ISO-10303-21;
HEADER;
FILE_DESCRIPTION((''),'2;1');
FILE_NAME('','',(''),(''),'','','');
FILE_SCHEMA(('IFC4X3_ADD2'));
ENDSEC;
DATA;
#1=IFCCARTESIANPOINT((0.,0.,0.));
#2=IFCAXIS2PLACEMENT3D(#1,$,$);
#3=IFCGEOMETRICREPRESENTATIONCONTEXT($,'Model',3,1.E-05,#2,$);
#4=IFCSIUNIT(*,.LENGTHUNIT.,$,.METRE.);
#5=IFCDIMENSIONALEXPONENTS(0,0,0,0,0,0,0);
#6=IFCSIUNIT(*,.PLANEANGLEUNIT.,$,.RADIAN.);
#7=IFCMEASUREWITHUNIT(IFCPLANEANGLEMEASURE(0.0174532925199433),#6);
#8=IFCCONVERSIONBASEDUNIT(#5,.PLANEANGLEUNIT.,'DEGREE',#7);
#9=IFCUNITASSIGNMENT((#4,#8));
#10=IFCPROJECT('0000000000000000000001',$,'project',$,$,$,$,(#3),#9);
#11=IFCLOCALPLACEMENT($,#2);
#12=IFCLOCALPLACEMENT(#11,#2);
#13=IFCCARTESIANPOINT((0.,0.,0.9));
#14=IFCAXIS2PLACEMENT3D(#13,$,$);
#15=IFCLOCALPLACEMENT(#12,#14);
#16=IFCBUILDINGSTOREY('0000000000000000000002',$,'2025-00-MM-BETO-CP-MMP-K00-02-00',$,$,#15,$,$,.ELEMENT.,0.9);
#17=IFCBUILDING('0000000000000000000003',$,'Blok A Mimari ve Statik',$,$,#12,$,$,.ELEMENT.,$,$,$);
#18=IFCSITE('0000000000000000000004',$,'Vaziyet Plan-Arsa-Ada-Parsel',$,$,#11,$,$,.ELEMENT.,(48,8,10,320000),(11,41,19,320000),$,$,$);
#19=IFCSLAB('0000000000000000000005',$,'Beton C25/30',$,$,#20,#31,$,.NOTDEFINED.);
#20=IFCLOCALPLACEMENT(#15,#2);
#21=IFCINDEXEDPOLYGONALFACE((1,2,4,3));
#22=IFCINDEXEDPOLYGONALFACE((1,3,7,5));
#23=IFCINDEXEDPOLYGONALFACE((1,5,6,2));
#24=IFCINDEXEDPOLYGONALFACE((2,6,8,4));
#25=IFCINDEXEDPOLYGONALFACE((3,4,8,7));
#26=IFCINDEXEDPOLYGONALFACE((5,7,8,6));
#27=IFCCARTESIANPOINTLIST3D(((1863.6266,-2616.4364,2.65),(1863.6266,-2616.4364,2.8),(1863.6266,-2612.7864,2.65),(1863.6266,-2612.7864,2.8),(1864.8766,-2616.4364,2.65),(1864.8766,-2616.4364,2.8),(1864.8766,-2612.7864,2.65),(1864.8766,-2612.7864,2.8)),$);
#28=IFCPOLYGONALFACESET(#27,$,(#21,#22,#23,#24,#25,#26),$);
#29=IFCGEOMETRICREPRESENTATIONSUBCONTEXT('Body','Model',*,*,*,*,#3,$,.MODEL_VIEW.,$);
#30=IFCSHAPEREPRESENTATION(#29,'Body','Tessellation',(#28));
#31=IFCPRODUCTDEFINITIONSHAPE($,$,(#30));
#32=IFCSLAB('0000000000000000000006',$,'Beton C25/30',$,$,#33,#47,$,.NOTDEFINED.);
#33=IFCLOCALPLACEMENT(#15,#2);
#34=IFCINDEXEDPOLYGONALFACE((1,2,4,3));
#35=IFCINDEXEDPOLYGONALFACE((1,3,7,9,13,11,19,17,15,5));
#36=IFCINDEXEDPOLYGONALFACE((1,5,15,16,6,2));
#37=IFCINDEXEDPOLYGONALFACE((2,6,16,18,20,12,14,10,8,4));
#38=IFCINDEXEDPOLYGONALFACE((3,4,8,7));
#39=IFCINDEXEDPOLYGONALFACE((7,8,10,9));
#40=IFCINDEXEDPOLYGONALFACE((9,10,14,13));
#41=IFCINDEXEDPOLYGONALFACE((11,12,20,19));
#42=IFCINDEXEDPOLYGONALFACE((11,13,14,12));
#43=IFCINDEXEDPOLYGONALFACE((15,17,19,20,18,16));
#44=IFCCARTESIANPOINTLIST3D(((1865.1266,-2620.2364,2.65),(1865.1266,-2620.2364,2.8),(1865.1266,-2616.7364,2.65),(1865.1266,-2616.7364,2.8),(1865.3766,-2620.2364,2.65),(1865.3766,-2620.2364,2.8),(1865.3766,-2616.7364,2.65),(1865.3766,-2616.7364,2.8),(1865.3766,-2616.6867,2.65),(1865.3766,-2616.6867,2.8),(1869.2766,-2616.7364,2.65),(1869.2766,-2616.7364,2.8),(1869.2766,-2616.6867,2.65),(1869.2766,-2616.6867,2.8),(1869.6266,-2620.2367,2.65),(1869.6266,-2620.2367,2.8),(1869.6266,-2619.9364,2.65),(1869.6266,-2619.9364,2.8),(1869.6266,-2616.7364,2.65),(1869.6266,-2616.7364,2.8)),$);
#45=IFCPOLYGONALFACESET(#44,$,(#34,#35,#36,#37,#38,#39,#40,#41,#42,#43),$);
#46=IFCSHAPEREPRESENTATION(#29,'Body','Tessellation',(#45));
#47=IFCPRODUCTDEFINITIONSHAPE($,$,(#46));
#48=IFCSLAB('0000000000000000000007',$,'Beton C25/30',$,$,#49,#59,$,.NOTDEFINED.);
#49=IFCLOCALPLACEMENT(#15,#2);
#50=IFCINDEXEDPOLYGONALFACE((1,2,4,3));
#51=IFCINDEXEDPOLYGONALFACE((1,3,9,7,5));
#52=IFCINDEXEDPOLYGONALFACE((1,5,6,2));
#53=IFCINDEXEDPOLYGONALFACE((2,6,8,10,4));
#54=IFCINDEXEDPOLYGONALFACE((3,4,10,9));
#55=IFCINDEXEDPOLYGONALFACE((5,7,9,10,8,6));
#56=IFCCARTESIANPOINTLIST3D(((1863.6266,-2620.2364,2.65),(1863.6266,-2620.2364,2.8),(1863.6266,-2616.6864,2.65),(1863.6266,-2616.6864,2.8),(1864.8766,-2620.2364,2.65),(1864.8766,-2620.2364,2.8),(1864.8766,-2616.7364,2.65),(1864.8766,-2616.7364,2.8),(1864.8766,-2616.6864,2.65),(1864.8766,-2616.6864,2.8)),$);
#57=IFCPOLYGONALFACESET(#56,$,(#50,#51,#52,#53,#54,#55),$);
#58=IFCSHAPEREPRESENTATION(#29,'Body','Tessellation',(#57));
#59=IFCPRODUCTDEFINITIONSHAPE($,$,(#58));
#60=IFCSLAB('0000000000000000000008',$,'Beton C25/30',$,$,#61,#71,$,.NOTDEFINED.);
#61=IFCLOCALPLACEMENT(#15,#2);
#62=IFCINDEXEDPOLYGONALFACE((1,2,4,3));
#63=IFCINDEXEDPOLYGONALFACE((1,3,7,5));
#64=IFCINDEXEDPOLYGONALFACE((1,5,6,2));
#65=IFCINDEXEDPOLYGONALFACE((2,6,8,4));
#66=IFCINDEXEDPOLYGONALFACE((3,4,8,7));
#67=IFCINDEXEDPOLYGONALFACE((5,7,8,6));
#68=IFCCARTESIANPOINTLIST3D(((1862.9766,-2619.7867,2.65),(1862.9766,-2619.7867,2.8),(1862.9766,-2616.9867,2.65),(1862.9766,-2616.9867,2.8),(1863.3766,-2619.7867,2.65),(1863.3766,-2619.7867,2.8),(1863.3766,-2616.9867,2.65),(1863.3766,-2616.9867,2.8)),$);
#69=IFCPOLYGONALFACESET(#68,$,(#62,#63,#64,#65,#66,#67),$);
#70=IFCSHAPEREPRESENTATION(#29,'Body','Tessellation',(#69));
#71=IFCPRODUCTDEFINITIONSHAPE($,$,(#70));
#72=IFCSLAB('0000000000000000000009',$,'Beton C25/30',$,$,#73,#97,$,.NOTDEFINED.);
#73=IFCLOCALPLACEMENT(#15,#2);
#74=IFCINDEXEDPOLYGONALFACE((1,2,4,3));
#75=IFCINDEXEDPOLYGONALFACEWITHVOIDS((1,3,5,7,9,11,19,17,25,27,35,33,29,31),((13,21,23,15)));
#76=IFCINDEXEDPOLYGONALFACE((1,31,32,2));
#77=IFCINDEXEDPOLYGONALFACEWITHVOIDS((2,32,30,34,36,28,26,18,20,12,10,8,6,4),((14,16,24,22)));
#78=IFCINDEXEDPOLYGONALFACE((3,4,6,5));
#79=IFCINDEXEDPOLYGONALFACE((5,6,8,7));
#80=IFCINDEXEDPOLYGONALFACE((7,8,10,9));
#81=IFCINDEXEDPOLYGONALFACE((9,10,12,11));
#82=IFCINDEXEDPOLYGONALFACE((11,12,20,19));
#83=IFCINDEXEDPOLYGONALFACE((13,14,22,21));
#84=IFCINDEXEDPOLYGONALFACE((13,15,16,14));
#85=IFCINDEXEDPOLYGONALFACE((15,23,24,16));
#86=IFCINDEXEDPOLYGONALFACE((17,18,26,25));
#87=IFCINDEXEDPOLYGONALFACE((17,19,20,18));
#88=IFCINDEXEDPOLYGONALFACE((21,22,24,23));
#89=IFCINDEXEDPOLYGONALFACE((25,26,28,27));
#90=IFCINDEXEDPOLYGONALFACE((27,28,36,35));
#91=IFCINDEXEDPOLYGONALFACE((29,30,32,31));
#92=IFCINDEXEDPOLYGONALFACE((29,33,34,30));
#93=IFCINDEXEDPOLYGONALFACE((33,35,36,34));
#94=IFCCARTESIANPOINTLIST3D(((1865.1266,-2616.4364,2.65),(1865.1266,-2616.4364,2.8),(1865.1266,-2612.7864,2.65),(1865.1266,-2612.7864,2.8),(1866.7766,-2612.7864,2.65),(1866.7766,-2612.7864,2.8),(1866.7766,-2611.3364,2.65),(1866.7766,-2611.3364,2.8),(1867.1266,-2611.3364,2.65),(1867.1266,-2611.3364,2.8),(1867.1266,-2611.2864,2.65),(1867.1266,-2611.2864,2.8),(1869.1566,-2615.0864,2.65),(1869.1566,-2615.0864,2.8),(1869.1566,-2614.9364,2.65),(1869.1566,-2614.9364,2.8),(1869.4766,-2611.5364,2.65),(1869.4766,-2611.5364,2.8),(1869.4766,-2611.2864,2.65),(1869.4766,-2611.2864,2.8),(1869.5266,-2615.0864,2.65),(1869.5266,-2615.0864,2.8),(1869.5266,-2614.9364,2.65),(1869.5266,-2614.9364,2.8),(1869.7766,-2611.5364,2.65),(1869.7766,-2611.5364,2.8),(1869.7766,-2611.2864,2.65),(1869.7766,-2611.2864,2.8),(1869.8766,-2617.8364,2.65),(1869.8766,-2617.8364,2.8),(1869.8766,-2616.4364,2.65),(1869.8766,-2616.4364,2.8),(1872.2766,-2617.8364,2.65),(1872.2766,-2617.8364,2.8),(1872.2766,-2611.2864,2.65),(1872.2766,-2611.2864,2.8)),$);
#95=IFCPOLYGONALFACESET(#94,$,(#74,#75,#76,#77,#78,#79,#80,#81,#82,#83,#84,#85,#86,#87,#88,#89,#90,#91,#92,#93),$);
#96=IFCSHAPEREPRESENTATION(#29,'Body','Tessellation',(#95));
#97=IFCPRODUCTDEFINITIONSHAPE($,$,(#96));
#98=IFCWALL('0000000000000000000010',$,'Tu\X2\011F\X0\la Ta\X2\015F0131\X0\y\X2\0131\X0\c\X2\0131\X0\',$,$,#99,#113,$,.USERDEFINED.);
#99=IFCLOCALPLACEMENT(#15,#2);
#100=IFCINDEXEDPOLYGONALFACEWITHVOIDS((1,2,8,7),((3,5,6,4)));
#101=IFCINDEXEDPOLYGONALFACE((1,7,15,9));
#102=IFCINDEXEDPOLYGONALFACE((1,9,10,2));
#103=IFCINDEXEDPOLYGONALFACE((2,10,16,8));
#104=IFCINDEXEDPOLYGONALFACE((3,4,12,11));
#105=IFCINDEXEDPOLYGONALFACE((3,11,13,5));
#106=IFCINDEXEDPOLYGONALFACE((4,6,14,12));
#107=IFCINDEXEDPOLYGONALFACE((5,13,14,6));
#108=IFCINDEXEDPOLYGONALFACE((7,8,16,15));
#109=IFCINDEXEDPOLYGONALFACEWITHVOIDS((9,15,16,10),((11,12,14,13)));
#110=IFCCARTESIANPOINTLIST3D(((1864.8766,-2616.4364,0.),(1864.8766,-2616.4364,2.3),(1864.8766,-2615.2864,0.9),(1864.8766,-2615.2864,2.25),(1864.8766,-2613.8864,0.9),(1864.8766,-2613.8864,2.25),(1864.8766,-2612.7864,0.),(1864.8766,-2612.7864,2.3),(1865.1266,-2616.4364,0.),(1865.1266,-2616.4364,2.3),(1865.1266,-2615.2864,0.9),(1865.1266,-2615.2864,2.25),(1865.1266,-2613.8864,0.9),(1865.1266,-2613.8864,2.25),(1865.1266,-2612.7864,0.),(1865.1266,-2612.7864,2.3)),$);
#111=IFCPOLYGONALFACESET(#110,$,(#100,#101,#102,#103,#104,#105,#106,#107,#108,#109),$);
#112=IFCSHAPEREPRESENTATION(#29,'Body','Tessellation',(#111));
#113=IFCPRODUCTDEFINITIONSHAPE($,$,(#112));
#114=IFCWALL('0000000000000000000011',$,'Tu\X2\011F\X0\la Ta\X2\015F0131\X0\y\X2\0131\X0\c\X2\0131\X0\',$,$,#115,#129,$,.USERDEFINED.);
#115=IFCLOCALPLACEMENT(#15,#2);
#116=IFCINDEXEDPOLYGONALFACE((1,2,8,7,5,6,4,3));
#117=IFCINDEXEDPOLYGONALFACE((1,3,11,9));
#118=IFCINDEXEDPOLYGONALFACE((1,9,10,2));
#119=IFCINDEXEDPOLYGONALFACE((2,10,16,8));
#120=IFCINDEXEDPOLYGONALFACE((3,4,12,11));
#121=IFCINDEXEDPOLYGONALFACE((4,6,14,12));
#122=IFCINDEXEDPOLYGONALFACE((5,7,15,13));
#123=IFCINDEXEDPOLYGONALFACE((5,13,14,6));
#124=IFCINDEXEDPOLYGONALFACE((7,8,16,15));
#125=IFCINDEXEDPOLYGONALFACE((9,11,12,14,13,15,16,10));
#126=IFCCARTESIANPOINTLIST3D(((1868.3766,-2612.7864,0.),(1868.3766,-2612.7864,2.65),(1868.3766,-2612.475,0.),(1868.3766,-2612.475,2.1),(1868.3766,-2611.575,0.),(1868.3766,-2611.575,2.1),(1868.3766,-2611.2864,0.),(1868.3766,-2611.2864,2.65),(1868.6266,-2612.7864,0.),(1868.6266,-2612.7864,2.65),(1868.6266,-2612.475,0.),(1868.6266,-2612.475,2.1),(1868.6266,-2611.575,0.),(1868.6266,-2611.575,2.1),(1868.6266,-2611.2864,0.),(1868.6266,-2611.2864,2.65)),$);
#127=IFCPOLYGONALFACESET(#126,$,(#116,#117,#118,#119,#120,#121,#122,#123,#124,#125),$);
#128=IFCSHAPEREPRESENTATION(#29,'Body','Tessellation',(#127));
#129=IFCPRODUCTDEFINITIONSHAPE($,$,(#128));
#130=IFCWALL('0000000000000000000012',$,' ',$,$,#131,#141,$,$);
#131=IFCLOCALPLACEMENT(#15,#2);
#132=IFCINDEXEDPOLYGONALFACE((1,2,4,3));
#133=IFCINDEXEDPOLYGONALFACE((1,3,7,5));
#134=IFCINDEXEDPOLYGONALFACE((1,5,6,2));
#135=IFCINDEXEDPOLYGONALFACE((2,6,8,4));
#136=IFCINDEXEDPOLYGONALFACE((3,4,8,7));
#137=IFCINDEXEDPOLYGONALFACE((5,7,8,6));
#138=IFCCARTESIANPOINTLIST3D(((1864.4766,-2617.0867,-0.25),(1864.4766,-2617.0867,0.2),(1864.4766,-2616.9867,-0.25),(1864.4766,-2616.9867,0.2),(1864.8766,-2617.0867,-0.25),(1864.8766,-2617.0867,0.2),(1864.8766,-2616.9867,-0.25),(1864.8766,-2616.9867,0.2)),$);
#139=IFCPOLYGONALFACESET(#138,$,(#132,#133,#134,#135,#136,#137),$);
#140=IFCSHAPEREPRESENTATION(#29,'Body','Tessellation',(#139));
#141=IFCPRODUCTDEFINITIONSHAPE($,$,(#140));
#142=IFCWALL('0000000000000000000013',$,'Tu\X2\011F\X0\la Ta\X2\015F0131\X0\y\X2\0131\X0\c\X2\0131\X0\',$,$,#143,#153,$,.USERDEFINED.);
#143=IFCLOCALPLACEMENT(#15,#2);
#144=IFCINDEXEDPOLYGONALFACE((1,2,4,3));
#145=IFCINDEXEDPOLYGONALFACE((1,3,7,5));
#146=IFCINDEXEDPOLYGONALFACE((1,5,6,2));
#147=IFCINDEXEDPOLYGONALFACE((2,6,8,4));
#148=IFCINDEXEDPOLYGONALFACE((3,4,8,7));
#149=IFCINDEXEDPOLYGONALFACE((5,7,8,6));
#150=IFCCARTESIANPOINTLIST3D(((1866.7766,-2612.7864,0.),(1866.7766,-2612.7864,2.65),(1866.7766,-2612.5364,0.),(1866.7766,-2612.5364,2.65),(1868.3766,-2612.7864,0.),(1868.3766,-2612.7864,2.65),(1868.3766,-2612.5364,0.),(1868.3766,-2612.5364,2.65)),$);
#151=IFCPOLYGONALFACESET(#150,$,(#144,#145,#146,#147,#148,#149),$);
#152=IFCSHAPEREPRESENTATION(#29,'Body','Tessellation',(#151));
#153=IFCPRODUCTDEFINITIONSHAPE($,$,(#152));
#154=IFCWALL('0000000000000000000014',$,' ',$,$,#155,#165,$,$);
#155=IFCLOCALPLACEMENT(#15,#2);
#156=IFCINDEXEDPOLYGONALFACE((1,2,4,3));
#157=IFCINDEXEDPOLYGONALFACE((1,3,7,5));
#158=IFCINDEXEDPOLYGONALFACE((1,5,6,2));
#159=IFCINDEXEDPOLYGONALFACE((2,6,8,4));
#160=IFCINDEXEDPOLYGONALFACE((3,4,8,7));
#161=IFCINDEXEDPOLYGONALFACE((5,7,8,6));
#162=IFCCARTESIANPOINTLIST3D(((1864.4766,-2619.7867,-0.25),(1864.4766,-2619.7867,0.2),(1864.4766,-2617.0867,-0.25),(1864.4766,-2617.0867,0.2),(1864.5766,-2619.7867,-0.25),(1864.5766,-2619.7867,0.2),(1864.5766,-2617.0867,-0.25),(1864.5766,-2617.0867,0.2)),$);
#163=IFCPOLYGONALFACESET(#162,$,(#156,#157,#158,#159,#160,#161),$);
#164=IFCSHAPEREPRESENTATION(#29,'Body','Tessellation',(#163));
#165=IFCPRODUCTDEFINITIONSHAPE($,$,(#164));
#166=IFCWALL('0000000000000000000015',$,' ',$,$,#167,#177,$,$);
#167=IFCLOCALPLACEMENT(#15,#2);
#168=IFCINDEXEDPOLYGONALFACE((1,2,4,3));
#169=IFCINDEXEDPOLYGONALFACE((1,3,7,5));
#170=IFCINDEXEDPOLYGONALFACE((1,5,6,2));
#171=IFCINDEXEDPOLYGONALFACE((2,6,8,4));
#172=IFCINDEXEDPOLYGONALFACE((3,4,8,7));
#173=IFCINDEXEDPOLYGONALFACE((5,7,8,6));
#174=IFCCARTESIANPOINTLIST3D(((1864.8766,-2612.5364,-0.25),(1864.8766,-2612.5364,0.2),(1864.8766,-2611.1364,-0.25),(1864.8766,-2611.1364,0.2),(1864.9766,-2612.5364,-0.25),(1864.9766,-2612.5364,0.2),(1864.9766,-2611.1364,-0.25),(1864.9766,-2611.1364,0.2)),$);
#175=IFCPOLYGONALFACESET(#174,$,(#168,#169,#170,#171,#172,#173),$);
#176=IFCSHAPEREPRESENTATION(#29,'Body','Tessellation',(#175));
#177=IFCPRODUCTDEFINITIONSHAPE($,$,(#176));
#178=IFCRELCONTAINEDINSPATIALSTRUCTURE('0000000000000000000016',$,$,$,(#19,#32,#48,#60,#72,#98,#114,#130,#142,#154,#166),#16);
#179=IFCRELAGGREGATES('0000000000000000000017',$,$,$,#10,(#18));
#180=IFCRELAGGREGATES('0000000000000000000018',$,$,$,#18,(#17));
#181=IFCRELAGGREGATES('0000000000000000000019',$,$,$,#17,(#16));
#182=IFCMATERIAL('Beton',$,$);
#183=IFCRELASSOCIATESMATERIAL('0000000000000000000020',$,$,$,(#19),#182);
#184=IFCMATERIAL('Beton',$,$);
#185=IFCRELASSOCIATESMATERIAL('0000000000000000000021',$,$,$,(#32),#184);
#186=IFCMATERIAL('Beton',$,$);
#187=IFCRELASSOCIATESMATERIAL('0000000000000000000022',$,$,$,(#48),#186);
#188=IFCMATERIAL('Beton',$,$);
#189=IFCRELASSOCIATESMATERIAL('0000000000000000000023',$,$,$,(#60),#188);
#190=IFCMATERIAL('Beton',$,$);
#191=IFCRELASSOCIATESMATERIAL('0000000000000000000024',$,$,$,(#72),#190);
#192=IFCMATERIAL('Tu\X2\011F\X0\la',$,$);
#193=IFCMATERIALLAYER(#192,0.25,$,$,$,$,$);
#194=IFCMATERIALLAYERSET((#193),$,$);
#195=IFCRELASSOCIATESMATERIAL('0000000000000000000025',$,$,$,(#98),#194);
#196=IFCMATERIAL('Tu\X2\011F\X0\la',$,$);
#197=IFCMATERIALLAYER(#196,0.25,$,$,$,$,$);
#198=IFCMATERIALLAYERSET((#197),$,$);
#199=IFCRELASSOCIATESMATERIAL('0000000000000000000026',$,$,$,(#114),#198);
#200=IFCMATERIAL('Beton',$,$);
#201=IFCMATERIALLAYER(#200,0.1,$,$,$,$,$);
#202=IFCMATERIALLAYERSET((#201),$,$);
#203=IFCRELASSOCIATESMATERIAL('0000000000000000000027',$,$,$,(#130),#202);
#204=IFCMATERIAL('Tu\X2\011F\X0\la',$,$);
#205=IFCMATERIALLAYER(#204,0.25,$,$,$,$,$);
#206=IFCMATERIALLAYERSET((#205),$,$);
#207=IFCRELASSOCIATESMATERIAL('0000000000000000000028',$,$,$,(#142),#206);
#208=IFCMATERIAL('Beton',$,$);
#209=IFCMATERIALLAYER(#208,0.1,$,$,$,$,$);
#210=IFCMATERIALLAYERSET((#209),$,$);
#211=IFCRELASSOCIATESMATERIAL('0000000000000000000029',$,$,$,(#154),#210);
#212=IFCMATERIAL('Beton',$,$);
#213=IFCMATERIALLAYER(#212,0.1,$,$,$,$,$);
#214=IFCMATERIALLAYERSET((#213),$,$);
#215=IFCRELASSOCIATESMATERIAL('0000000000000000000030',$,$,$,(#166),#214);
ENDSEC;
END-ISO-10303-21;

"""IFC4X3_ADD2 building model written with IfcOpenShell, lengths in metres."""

from ifc_helpers import new_model, entity, si_unit, converted_unit, frame, frame_2d, origin, origin_with_axes, place, context, subcontext, project, spatial, polyline, rectangle, outline, extrude, material, layer, layer_set, layer_usage, element, save


model = new_model("IFC4X3_ADD2")

# Units and contexts
model_context = context("Model", 3, precision=1e-05, world=origin())
body_context = subcontext(model_context, "Body", "Model", "MODEL_VIEW")
ifc_project = project(units=[si_unit("LENGTHUNIT", "METRE"), converted_unit("PLANEANGLEUNIT", "DEGREE", entity("IfcPlaneAngleMeasure", 0.0174532925199433), si_unit("PLANEANGLEUNIT", "RADIAN"), dimensions=[0, 0, 0, 0, 0, 0, 0])], contexts=[model_context])

# Site, building, storey
site_placement = place(None, origin())
site = spatial("IfcSite", under=ifc_project, at=site_placement, Name="Vaziyet Plan-Arsa-Ada-Parsel", CompositionType="ELEMENT", RefLatitude=(48, 8, 10, 320000), RefLongitude=(11, 41, 19, 320000))
building_placement = place(site_placement, origin())
building = spatial("IfcBuilding", under=site, at=building_placement, Name="Blok A Mimari ve Statik", CompositionType="ELEMENT")
storey_placement = place(building_placement, frame((0.0, 0.0, 0.9)))
storey = spatial("IfcBuildingStorey", under=building, at=storey_placement, Name="2025-00-MM-BETO-CP-MMP-K00-02-00", CompositionType="ELEMENT", Elevation=0.9)

# Slabs
ifc_material_1 = material(Name="Beton")
slab_1_placement = place(storey_placement, frame((1863.6266, -2616.4364, 2.65)))
element("IfcSlab", 1, at=slab_1_placement, inside=storey, material=ifc_material_1, Name="Beton C25/30", PredefinedType="NOTDEFINED", context=body_context, shape_type="SweptSolid", body=[
    extrude(rectangle(XDim=1.25, YDim=3.65, at=frame_2d((0.625, 1.825), x_axis=(1.0, 0.0))), origin_with_axes(), (0.0, 0.0, 1.0), 0.15),
])
ifc_material_2 = material(Name="Beton")
slab_2_placement = place(storey_placement, frame((1865.1266, -2620.2367, 2.65)))
element("IfcSlab", 2, at=slab_2_placement, inside=storey, material=ifc_material_2, Name="Beton C25/30", PredefinedType="NOTDEFINED", context=body_context, shape_type="SweptSolid", body=[
    extrude(outline(polyline([(4.15, 3.55), (0.25, 3.55), (0.25, 3.5003), (0.0, 3.5003), (0.0, 0.0003), (0.25, 0.0003), (4.5, 0.0), (4.5, 0.3003), (4.5, 3.5003), (4.15, 3.5003), (4.15, 3.55)])), origin_with_axes(), (0.0, 0.0, 1.0), 0.15),
])
ifc_material_3 = material(Name="Beton")
slab_3_placement = place(storey_placement, frame((1863.6266, -2620.2364, 2.65)))
element("IfcSlab", 3, at=slab_3_placement, inside=storey, material=ifc_material_3, Name="Beton C25/30", PredefinedType="NOTDEFINED", context=body_context, shape_type="SweptSolid", body=[
    extrude(outline(polyline([(0.0, 3.55), (0.0, 0.0), (1.25, 0.0), (1.25, 3.5), (1.25, 3.55), (0.0, 3.55)])), origin_with_axes(), (0.0, 0.0, 1.0), 0.15),
])
ifc_material_4 = material(Name="Beton")
slab_4_placement = place(storey_placement, frame((1862.9766, -2619.7867, 2.65)))
element("IfcSlab", 4, at=slab_4_placement, inside=storey, material=ifc_material_4, Name="Beton C25/30", PredefinedType="NOTDEFINED", context=body_context, shape_type="SweptSolid", body=[
    extrude(rectangle(XDim=2.8, YDim=0.4, at=frame_2d((0.2, -1.4), x_axis=(0.0, -1.0))), frame((0.0, 2.8, 0.0), z_axis=(0.0, 0.0, 1.0), x_axis=(1.0, 0.0, 0.0)), (0.0, 0.0, 1.0), 0.15),
])

# Slab, opening
ifc_material_5 = material(Name="Beton")
slab_5_placement = place(storey_placement, frame((1865.1266, -2617.8364, 2.65)))
slab_5 = element("IfcSlab", 5, at=slab_5_placement, inside=storey, material=ifc_material_5, Name="Beton C25/30", PredefinedType="NOTDEFINED", context=body_context, shape_type="SweptSolid", body=[
    extrude(outline(polyline([(4.75, 0.0), (7.15, 0.0), (7.15, 6.55), (4.65, 6.55), (4.65, 6.3), (4.35, 6.3), (4.35, 6.55), (2.0, 6.55), (2.0, 6.5), (1.65, 6.5), (1.65, 5.3), (1.65, 5.05), (0.0, 5.05), (0.0, 1.4), (4.75, 1.4), (4.75, 0.0)])), origin_with_axes(), (0.0, 0.0, 1.0), 0.15),
])
opening_1_placement = place(slab_5_placement, frame((4.03, 2.75, 0.0)))
element("IfcOpeningElement", 6, at=opening_1_placement, cuts=slab_5, PredefinedType="OPENING", context=body_context, shape_type="SweptSolid", body=[
    extrude(rectangle(XDim=0.15, YDim=0.37, at=frame_2d((0.0, 0.0), x_axis=(0.0, -1.0))), frame((0.185, 0.075, 0.0), z_axis=(0.0, 0.0, 1.0), x_axis=(1.0, 0.0, 0.0)), (0.0, 0.0, 1.0), 0.15),
])

# Walls, openings
ifc_material_6 = material(Name="Tuğla")
ifc_layer_1 = layer(ifc_material_6, 0.25)
ifc_layer_set_1 = layer_set([ifc_layer_1])
ifc_layer_usage_1 = layer_usage(ifc_layer_set_1, "AXIS2", "POSITIVE", 0.0)
wall_1_placement = place(storey_placement, frame((1864.8766, -2612.7864, 0.0), z_axis=(0.0, 0.0, 1.0), x_axis=(0.0, -1.0, 0.0)))
wall_1 = element("IfcWall", 7, at=wall_1_placement, inside=storey, material=ifc_layer_usage_1, Name="Tuğla Taşıyıcı", PredefinedType="USERDEFINED", context=body_context, shape_type="SweptSolid", body=[
    extrude(rectangle(XDim=3.65, YDim=0.25, at=frame_2d((1.825, 0.125), x_axis=(1.0, 0.0))), origin_with_axes(), (0.0, 0.0, 1.0), 2.3),
])
opening_2_placement = place(wall_1_placement, frame((1.1, 0.0, 0.9), z_axis=(0.0, 1.0, 0.0), x_axis=(0.0, 0.0, 1.0)))
element("IfcOpeningElement", 8, at=opening_2_placement, cuts=wall_1, PredefinedType="OPENING", context=body_context, shape_type="SweptSolid", body=[
    extrude(outline(polyline([(1.35, 1.4), (1.35, 0.0), (0.0, 0.0), (0.0, 1.4), (1.35, 1.4)])), origin_with_axes(), (0.0, 0.0, 1.0), 0.25),
])
ifc_material_7 = material(Name="Tuğla")
ifc_layer_2 = layer(ifc_material_7, 0.25)
ifc_layer_set_2 = layer_set([ifc_layer_2])
ifc_layer_usage_2 = layer_usage(ifc_layer_set_2, "AXIS2", "POSITIVE", 0.0)
wall_2_placement = place(storey_placement, frame((1868.3766, -2611.2864, 0.0), z_axis=(0.0, 0.0, 1.0), x_axis=(0.0, -1.0, 0.0)))
wall_2 = element("IfcWall", 9, at=wall_2_placement, inside=storey, material=ifc_layer_usage_2, Name="Tuğla Taşıyıcı", PredefinedType="USERDEFINED", context=body_context, shape_type="SweptSolid", body=[
    extrude(rectangle(XDim=1.5, YDim=0.25, at=frame_2d((0.75, 0.125), x_axis=(1.0, 0.0))), origin_with_axes(), (0.0, 0.0, 1.0), 2.65),
])
opening_3_placement = place(wall_2_placement, frame((1.1886, 0.25, 0.0), z_axis=(0.0, -1.0, 0.0), x_axis=(0.0, 0.0, 1.0)))
element("IfcOpeningElement", 10, at=opening_3_placement, cuts=wall_2, PredefinedType="OPENING", context=body_context, shape_type="SweptSolid", body=[
    extrude(outline(polyline([(2.1, 0.9), (2.1, 0.0), (0.0, 0.0), (0.0, 0.9), (2.1, 0.9)])), origin_with_axes(), (0.0, 0.0, 1.0), 0.25),
])

# Walls
ifc_material_8 = material(Name="Beton")
ifc_layer_3 = layer(ifc_material_8, 0.1)
ifc_layer_set_3 = layer_set([ifc_layer_3])
ifc_layer_usage_3 = layer_usage(ifc_layer_set_3, "AXIS2", "POSITIVE", 0.0)
wall_3_placement = place(storey_placement, frame((1864.8766, -2616.9867, -0.25), z_axis=(0.0, 0.0, 1.0), x_axis=(-1.0, 0.0, 0.0)))
element("IfcWall", 11, at=wall_3_placement, inside=storey, material=ifc_layer_usage_3, Name=" ", context=body_context, shape_type="SweptSolid", body=[
    extrude(rectangle(XDim=0.4, YDim=0.1, at=frame_2d((0.2, 0.05), x_axis=(1.0, 0.0))), origin_with_axes(), (0.0, 0.0, 1.0), 0.45),
])
ifc_material_9 = material(Name="Tuğla")
ifc_layer_4 = layer(ifc_material_9, 0.25)
ifc_layer_set_4 = layer_set([ifc_layer_4])
ifc_layer_usage_4 = layer_usage(ifc_layer_set_4, "AXIS2", "POSITIVE", 0.0)
wall_4_placement = place(storey_placement, frame((1868.3766, -2612.5364, 0.0), z_axis=(0.0, 0.0, 1.0), x_axis=(-1.0, 0.0, 0.0)))
element("IfcWall", 12, at=wall_4_placement, inside=storey, material=ifc_layer_usage_4, Name="Tuğla Taşıyıcı", PredefinedType="USERDEFINED", context=body_context, shape_type="SweptSolid", body=[
    extrude(rectangle(XDim=1.6, YDim=0.25, at=frame_2d((0.8, 0.125), x_axis=(1.0, 0.0))), origin_with_axes(), (0.0, 0.0, 1.0), 2.65),
])
ifc_material_10 = material(Name="Beton")
ifc_layer_5 = layer(ifc_material_10, 0.1)
ifc_layer_set_5 = layer_set([ifc_layer_5])
ifc_layer_usage_5 = layer_usage(ifc_layer_set_5, "AXIS2", "POSITIVE", 0.0)
wall_5_placement = place(storey_placement, frame((1864.4766, -2617.0867, -0.25), z_axis=(0.0, 0.0, 1.0), x_axis=(0.0, -1.0, 0.0)))
element("IfcWall", 13, at=wall_5_placement, inside=storey, material=ifc_layer_usage_5, Name=" ", context=body_context, shape_type="SweptSolid", body=[
    extrude(rectangle(XDim=2.7, YDim=0.1, at=frame_2d((1.35, 0.05), x_axis=(1.0, 0.0))), origin_with_axes(), (0.0, 0.0, 1.0), 0.45),
])
ifc_material_11 = material(Name="Beton")
ifc_layer_6 = layer(ifc_material_11, 0.1)
ifc_layer_set_6 = layer_set([ifc_layer_6])
ifc_layer_usage_6 = layer_usage(ifc_layer_set_6, "AXIS2", "POSITIVE", 0.0)
wall_6_placement = place(storey_placement, frame((1864.8766, -2611.1364, -0.25), z_axis=(0.0, 0.0, 1.0), x_axis=(0.0, -1.0, 0.0)))
element("IfcWall", 14, at=wall_6_placement, inside=storey, material=ifc_layer_usage_6, Name=" ", context=body_context, shape_type="SweptSolid", body=[
    extrude(rectangle(XDim=1.4, YDim=0.1, at=frame_2d((0.7, 0.05), x_axis=(1.0, 0.0))), origin_with_axes(), (0.0, 0.0, 1.0), 0.45),
])

save(model, "model.ifc")
